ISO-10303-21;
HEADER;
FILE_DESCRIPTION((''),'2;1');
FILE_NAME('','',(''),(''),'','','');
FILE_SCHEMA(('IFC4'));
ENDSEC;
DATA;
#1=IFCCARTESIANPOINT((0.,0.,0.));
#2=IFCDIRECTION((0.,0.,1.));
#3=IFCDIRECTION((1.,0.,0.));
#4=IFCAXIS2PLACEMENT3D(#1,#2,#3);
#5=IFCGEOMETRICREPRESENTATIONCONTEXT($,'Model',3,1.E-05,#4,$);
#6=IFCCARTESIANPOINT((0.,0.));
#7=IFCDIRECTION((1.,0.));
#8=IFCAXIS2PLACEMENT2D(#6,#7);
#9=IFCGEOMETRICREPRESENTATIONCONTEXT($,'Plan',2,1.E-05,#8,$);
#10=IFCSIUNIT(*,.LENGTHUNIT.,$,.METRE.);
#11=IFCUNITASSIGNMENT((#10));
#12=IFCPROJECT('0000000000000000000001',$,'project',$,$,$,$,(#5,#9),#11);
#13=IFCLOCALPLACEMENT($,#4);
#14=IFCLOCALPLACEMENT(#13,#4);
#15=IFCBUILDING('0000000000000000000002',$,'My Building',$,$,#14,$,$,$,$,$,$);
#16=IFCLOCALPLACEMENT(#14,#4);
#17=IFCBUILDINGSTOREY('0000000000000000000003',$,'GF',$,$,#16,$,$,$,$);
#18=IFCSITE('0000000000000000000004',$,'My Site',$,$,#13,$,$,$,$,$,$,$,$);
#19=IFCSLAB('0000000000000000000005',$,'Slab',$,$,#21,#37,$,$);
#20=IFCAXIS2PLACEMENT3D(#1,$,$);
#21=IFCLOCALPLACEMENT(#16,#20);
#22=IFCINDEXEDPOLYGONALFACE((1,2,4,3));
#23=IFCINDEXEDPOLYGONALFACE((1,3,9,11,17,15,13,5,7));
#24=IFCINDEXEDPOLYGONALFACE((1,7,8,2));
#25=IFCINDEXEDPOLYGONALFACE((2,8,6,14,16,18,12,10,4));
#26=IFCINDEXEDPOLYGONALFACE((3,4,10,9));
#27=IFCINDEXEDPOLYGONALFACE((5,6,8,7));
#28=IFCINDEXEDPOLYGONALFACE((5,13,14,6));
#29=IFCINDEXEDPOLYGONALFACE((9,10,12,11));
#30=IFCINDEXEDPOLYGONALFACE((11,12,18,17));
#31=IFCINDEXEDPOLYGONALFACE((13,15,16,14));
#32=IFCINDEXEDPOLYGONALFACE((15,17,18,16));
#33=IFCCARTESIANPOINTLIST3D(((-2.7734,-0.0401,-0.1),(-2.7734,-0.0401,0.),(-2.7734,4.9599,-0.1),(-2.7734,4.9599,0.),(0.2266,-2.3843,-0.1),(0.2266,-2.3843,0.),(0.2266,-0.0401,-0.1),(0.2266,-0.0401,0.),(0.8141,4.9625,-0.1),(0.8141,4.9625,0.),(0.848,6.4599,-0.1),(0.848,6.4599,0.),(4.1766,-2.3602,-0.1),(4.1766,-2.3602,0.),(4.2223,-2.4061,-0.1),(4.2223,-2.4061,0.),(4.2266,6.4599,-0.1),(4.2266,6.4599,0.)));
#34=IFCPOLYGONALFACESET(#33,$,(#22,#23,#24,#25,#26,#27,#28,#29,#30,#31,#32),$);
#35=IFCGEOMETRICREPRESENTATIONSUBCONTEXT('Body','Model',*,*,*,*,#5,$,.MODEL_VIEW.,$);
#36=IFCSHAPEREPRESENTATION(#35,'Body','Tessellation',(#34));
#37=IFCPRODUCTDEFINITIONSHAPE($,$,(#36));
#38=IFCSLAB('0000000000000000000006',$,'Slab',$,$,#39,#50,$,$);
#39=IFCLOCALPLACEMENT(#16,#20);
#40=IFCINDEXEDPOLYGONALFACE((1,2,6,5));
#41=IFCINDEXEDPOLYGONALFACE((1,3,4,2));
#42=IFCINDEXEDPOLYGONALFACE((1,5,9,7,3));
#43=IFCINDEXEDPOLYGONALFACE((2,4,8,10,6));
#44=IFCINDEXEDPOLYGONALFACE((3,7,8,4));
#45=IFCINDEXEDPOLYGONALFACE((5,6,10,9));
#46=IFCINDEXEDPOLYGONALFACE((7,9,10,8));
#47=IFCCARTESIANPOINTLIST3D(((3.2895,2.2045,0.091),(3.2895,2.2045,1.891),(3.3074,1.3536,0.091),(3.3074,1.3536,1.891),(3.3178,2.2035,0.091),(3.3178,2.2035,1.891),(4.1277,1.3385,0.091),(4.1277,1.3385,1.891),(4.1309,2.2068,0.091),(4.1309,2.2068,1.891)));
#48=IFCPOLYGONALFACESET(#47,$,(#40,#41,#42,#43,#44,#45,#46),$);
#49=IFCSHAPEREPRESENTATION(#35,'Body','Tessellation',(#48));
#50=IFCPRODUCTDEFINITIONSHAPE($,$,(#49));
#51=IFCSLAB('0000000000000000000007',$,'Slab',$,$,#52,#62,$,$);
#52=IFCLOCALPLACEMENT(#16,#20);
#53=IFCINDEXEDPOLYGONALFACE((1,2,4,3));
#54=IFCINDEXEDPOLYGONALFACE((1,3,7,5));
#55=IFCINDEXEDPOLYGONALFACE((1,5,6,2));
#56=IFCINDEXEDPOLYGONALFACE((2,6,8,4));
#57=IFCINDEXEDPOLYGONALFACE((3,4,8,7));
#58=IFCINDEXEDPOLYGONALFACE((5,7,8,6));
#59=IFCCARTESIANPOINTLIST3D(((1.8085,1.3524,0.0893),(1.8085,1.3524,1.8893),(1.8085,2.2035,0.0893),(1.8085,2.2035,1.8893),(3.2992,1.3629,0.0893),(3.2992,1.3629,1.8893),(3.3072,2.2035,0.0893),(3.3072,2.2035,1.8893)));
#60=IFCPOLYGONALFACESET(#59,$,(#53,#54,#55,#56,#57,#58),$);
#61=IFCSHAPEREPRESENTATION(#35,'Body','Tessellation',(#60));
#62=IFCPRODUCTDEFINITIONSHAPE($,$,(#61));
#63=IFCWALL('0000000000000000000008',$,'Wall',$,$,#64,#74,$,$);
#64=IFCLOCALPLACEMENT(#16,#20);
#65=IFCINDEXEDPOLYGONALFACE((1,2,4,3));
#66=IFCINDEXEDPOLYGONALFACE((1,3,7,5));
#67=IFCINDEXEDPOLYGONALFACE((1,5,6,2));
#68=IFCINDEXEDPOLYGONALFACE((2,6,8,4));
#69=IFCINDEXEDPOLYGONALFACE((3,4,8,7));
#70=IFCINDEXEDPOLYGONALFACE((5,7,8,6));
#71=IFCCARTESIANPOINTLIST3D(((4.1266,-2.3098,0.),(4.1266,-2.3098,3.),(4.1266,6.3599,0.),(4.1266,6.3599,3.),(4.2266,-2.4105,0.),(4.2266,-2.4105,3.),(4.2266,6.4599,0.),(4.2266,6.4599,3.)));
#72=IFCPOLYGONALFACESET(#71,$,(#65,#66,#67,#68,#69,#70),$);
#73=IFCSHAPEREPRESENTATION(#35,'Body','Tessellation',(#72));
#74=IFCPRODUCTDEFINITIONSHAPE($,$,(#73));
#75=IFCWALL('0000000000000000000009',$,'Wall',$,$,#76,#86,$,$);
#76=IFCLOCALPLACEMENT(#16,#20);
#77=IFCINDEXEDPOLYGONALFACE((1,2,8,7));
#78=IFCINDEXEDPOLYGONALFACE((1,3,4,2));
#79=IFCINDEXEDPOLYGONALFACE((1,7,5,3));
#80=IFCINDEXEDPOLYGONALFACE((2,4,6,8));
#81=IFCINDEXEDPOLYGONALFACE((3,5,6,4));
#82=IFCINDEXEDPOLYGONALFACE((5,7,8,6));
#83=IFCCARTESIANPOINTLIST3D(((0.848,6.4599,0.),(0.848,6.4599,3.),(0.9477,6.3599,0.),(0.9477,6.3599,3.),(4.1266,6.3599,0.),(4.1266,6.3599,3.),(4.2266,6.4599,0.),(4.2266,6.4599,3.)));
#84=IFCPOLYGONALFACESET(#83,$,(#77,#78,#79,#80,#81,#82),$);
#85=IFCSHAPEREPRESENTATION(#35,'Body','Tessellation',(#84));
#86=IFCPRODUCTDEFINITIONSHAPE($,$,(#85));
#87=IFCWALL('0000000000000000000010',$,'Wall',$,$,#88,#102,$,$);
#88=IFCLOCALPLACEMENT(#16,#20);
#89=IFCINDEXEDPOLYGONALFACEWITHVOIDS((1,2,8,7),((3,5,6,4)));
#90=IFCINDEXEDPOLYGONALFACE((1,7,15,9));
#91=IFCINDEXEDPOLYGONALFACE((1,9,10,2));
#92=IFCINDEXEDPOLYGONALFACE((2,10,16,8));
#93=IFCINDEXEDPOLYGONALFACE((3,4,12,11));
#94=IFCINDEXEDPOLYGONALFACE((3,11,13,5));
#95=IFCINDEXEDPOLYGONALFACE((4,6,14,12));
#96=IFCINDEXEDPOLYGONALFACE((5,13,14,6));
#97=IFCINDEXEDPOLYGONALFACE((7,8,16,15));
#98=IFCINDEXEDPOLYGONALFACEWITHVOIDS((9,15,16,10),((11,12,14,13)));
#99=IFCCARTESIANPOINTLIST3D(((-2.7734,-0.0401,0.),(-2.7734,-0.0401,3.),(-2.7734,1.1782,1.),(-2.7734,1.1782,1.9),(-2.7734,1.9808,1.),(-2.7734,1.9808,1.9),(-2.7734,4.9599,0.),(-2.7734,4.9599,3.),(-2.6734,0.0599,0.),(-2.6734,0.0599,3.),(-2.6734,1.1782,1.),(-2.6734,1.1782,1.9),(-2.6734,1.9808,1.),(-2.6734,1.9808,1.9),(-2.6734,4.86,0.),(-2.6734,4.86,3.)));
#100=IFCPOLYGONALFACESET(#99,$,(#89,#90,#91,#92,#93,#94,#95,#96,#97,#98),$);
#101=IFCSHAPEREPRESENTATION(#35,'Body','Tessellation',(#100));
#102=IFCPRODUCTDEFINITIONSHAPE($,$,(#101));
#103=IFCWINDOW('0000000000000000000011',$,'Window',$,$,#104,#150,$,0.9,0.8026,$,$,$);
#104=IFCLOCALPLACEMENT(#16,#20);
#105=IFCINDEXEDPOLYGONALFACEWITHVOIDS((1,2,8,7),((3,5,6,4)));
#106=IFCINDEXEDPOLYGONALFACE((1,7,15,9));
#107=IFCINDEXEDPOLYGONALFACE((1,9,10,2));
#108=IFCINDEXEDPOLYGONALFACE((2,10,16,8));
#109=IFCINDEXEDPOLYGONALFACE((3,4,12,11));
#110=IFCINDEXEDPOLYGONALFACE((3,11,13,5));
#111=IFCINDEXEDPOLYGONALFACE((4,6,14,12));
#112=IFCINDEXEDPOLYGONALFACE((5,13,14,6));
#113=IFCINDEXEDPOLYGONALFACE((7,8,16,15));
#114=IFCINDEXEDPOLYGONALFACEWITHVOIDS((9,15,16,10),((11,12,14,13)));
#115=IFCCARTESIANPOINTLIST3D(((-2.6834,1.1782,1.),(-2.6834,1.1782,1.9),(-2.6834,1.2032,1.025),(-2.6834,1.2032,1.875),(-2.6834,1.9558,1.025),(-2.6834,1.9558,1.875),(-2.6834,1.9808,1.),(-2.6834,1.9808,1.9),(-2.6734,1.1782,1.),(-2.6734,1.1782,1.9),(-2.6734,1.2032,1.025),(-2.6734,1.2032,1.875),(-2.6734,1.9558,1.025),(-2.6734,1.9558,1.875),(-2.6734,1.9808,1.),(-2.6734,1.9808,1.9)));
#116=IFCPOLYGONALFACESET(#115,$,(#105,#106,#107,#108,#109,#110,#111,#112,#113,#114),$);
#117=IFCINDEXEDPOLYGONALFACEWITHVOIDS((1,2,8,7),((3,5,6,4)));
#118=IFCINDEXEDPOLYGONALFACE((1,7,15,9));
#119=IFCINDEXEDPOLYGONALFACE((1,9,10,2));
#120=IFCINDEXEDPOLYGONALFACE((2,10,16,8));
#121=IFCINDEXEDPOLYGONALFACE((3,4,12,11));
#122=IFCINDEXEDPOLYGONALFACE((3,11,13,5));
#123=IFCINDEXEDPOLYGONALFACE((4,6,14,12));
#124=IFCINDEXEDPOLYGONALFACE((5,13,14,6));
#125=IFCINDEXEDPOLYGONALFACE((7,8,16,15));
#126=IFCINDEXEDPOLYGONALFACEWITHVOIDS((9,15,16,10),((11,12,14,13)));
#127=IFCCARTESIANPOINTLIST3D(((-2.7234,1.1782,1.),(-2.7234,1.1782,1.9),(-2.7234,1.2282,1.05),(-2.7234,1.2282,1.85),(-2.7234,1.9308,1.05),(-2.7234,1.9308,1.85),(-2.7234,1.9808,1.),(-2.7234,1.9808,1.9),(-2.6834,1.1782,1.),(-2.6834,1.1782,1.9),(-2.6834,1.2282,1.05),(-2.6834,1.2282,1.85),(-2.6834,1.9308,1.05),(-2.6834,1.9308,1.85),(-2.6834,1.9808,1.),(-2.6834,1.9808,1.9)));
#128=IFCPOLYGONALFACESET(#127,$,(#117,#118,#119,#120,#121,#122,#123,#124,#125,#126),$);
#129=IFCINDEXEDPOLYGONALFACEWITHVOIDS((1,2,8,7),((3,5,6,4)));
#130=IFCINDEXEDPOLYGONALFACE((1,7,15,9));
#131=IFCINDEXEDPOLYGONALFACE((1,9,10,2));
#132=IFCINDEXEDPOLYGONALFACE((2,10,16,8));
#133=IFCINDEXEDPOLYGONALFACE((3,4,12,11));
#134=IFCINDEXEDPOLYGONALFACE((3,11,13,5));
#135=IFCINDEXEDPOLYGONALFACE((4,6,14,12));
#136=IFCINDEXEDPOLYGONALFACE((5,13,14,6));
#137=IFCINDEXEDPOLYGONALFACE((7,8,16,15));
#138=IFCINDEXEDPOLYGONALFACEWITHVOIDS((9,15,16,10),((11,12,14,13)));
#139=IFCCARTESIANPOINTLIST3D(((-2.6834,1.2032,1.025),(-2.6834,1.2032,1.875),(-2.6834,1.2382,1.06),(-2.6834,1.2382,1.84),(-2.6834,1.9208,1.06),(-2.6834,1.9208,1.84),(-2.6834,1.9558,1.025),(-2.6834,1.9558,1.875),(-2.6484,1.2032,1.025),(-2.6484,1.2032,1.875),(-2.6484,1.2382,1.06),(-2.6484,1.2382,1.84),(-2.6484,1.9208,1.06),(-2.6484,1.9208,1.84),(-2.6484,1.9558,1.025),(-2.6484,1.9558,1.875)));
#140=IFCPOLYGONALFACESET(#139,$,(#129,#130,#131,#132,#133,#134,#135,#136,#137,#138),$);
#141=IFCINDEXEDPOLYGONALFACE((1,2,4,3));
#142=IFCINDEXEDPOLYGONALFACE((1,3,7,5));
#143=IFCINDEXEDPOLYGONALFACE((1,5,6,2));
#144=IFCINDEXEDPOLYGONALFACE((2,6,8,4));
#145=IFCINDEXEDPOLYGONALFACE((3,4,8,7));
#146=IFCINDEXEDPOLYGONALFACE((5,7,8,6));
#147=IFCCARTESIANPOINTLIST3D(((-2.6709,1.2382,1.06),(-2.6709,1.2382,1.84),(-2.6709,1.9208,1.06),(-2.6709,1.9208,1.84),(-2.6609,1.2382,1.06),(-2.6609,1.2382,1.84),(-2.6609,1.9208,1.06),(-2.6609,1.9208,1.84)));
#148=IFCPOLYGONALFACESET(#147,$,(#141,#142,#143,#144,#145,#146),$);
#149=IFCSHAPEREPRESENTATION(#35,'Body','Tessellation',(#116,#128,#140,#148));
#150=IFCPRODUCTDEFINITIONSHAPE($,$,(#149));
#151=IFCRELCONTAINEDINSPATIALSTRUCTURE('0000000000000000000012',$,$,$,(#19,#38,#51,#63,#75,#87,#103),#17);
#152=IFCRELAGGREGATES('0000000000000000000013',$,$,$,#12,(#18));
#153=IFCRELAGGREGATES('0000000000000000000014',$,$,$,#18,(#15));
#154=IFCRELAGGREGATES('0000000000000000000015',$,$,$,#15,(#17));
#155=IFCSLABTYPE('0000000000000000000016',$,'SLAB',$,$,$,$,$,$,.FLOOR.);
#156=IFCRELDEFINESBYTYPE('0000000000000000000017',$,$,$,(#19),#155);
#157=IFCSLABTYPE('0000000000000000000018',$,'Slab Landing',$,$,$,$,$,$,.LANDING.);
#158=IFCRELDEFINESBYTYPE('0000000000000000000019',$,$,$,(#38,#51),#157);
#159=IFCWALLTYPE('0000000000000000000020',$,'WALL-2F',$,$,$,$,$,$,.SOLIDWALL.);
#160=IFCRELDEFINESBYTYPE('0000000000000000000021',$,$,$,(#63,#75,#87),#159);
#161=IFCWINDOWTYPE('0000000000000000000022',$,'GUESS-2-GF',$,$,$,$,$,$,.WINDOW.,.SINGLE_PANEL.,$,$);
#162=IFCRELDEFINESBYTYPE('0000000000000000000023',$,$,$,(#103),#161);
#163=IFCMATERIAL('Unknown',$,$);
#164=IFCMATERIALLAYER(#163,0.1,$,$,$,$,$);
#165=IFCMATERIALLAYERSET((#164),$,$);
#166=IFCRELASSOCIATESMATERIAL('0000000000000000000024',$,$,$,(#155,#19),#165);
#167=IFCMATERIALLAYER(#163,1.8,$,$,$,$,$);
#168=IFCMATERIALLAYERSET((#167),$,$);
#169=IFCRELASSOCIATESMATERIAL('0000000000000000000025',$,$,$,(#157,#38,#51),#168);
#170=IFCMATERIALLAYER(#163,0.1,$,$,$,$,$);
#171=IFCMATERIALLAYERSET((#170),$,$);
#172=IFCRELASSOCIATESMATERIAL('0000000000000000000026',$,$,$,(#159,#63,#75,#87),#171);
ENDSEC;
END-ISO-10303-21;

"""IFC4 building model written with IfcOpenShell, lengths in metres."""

from ifc_helpers import new_model, entity, si_unit, frame, origin_with_axes, origin_2d_with_axis, place, context, subcontext, project, spatial, line, indexed_curve, outline, extrude, shape, source, transform, mapped, material, layer, layer_set, layer_usage, type_object, type_shapes, element, fill, save


model = new_model("IFC4")

# Units and contexts
model_context = context("Model", 3, precision=1e-05, world=origin_with_axes())
plan_context = context("Plan", 2, precision=1e-05, world=origin_2d_with_axis())
body_context_1 = subcontext(model_context, "Body", "Model", "MODEL_VIEW")
body_context_2 = subcontext(plan_context, "Body", "Plan", "PLAN_VIEW")
ifc_project = project(units=[si_unit("LENGTHUNIT", "METRE")], contexts=[model_context, plan_context])

# Site, building, storey
site_placement = place(None, origin_with_axes())
site = spatial("IfcSite", under=ifc_project, at=site_placement, Name="My Site")
building_placement = place(site_placement, origin_with_axes())
building = spatial("IfcBuilding", under=site, at=building_placement, Name="My Building")
storey_placement = place(building_placement, origin_with_axes())
storey = spatial("IfcBuildingStorey", under=building, at=storey_placement, Name="GF")

# Slabs
ifc_material_1 = material(Name="Unknown")
ifc_layer_1 = layer(ifc_material_1, 0.1)
ifc_layer_set_1 = layer_set([ifc_layer_1])
ifc_layer_usage_1 = layer_usage(ifc_layer_set_1, "AXIS3", "POSITIVE", -0.1)
slab_type_1 = type_object("IfcSlabType", Name="SLAB", PredefinedType="FLOOR", material=ifc_layer_set_1)
slab_1_placement = place(storey_placement, frame((4.2223, -2.4061, 0.0), z_axis=(0.0, 0.0, 1.0), x_axis=(1.0, 0.0, 0.0)))
element("IfcSlab", 1, at=slab_1_placement, inside=storey, type_object=slab_type_1, material=ifc_layer_usage_1, Name="Slab", context=body_context_1, shape_type="SweptSolid", body=[
    extrude(outline(indexed_curve([(0.0, 0.0), (0.0043, 8.866), (-3.3742, 8.866), (-3.4082, 7.3687), (-6.9957, 7.366), (-6.9957, 2.366), (-3.9957, 2.366), (-3.9957, 0.0219), (-0.0457, 0.046), (0.0, 0.0)])), frame((0.0, 0.0, -0.1), z_axis=(0.0, 0.0, 1.0), x_axis=(1.0, 0.0, 0.0)), (0.0, 0.0, 1.0), 0.1),
])
ifc_layer_2 = layer(ifc_material_1, 1.8)
ifc_layer_set_2 = layer_set([ifc_layer_2])
slab_type_2 = type_object("IfcSlabType", Name="Slab Landing", PredefinedType="LANDING", material=ifc_layer_set_2)
ifc_layer_usage_2 = layer_usage(ifc_layer_set_2, "AXIS3", "POSITIVE", -1.8)
slab_2_placement = place(storey_placement, frame((3.3178, 2.2035, 1.891), z_axis=(0.0, 0.0, 1.0), x_axis=(1.0, 0.0, 0.0)))
element("IfcSlab", 2, at=slab_2_placement, inside=storey, type_object=slab_type_2, material=ifc_layer_usage_2, Name="Slab", context=body_context_1, shape_type="SweptSolid", body=[
    extrude(outline(indexed_curve([(0.0, 0.0), (0.8131, 0.0032), (0.8098, -0.865), (-0.0104, -0.8499), (-0.0284, 0.001), (0.0, 0.0)])), frame((0.0, 0.0, -1.8), z_axis=(0.0, 0.0, 1.0), x_axis=(1.0, 0.0, 0.0)), (0.0, 0.0, 1.0), 1.8),
])
ifc_layer_usage_3 = layer_usage(ifc_layer_set_2, "AXIS3", "POSITIVE", -1.8)
slab_3_placement = place(storey_placement, frame((1.8085, 2.2035, 1.8893), z_axis=(0.0, 0.0, 1.0), x_axis=(1.0, 0.0, 0.0)))
element("IfcSlab", 3, at=slab_3_placement, inside=storey, type_object=slab_type_2, material=ifc_layer_usage_3, Name="Slab", context=body_context_1, shape_type="SweptSolid", body=[
    extrude(outline(indexed_curve([(0.0, 0.0), (0.0, -0.8511), (1.4906, -0.8406), (1.4986, 0.0), (0.0, 0.0)])), frame((0.0, 0.0, -1.8), z_axis=(0.0, 0.0, 1.0), x_axis=(1.0, 0.0, 0.0)), (0.0, 0.0, 1.0), 1.8),
])

# Walls
ifc_layer_3 = layer(ifc_material_1, 0.1)
ifc_layer_set_3 = layer_set([ifc_layer_3])
ifc_layer_usage_4 = layer_usage(ifc_layer_set_3, "AXIS2", "POSITIVE", 0.0)
wall_type_1 = type_object("IfcWallType", Name="WALL-2F", PredefinedType="SOLIDWALL", material=ifc_layer_set_3)
wall_1_placement = place(storey_placement, frame((4.2266, -2.4105, 0.0), z_axis=(0.0, 0.0, 1.0), x_axis=(0.0, 1.0, 0.0)))
element("IfcWall", 4, at=wall_1_placement, inside=storey, type_object=wall_type_1, material=ifc_layer_usage_4, Name="Wall", context=body_context_1, shape_type="SweptSolid", body=[
    extrude(outline(indexed_curve([(0.0, 0.0), (0.1007, 0.1), (8.7704, 0.1), (8.8704, 0.0)], segments=[line(1, 2, 3, 4, 1)])), origin_with_axes(), (0.0, 0.0, 1.0), 3.0),
])
ifc_layer_usage_5 = layer_usage(ifc_layer_set_3, "AXIS2", "POSITIVE", 0.0)
wall_2_placement = place(storey_placement, frame((4.2266, 6.4599, 0.0), z_axis=(0.0, 0.0, 1.0), x_axis=(-1.0, 0.0, 0.0)))
element("IfcWall", 5, at=wall_2_placement, inside=storey, type_object=wall_type_1, material=ifc_layer_usage_5, Name="Wall", context=body_context_1, shape_type="SweptSolid", body=[
    extrude(outline(indexed_curve([(0.0, 0.0), (0.1, 0.1), (3.2789, 0.1), (3.3786, 0.0)], segments=[line(1, 2, 3, 4, 1)])), origin_with_axes(), (0.0, 0.0, 1.0), 3.0),
])

# Wall, opening, window
ifc_layer_usage_6 = layer_usage(ifc_layer_set_3, "AXIS2", "POSITIVE", 0.0)
wall_3_placement = place(storey_placement, frame((-2.7734, 4.8599, 0.0), z_axis=(0.0, 0.0, 1.0), x_axis=(0.0, -1.0, 0.0)))
wall_3 = element("IfcWall", 6, at=wall_3_placement, inside=storey, type_object=wall_type_1, material=ifc_layer_usage_6, Name="Wall", context=body_context_1, shape_type="SweptSolid", body=[
    extrude(outline(indexed_curve([(-0.1, 0.0), (-0.0001, 0.1), (4.8, 0.1), (4.9, 0.0)], segments=[line(1, 2, 3, 4, 1)])), origin_with_axes(), (0.0, 0.0, 1.0), 3.0),
])
shared_shape_1 = source(origin_with_axes(), body_context_1, "Body", "SweptSolid", [
    extrude(outline(indexed_curve([(0.0, 0.0), (0.8026, 0.0), (0.8026, 0.9), (0.0, 0.9)], segments=[line(1, 2, 3, 4, 1)])), frame((0.0, -0.6, 0.0), z_axis=(0.0, -1.0, 0.0), x_axis=(1.0, 0.0, 0.0)), (0.0, 0.0, -1.0), 1.2),
])
opening_1_placement = place(wall_3_placement, frame((2.8791, 0.0, 1.0), z_axis=(0.0, 0.0, 1.0), x_axis=(1.0, 0.0, 0.0)))
opening_1 = element("IfcOpeningElement", 7, at=opening_1_placement, cuts=wall_3, PredefinedType="OPENING", context=body_context_1, shape_type="MappedRepresentation", body=[
    mapped(shared_shape_1, transform((0.0, 0.0, 0.0), x_axis=(1.0, 0.0, 0.0), y_axis=(0.0, 1.0, 0.0), z_axis=(0.0, 0.0, 1.0), scale=1.0)),
])
window_type_1 = type_object("IfcWindowType", Name="GUESS-2-GF", PartitioningType="SINGLE_PANEL", PredefinedType="WINDOW")
shared_shape_2 = source(origin_with_axes(), body_context_1, "Body", "SweptSolid", [
    extrude(outline(indexed_curve([(0.0, 0.0), (0.8026, 0.0), (0.8026, 0.9), (0.0, 0.9)], segments=[line(1, 2, 3, 4, 1)]), holes=[indexed_curve([(0.025, 0.025), (0.7776, 0.025), (0.7776, 0.875), (0.025, 0.875)], segments=[line(1, 2, 3, 4, 1)])]), frame((0.0, 0.09, 0.0), z_axis=(0.0, -1.0, 0.0), x_axis=(1.0, 0.0, 0.0)), (0.0, 0.0, -1.0), 0.01),
    extrude(outline(indexed_curve([(0.0, 0.0), (0.8026, 0.0), (0.8026, 0.9), (0.0, 0.9)], segments=[line(1, 2, 3, 4, 1)]), holes=[indexed_curve([(0.05, 0.05), (0.7526, 0.05), (0.7526, 0.85), (0.05, 0.85)], segments=[line(1, 2, 3, 4, 1)])]), frame((0.0, 0.05, 0.0), z_axis=(0.0, -1.0, 0.0), x_axis=(1.0, 0.0, 0.0)), (0.0, 0.0, -1.0), 0.04),
    extrude(outline(indexed_curve([(0.0, 0.0), (0.7526, 0.0), (0.7526, 0.85), (0.0, 0.85)], segments=[line(1, 2, 3, 4, 1)]), holes=[indexed_curve([(0.035, 0.035), (0.7176, 0.035), (0.7176, 0.815), (0.035, 0.815)], segments=[line(1, 2, 3, 4, 1)])]), frame((0.025, 0.09, 0.025), z_axis=(0.0, -1.0, 0.0), x_axis=(1.0, 0.0, 0.0)), (0.0, 0.0, -1.0), 0.035),
    extrude(outline(indexed_curve([(0.035, 0.035), (0.7176, 0.035), (0.7176, 0.815), (0.035, 0.815)], segments=[line(1, 2, 3, 4, 1)])), frame((0.025, 0.1025, 0.025), z_axis=(0.0, -1.0, 0.0), x_axis=(1.0, 0.0, 0.0)), (0.0, 0.0, -1.0), 0.01),
])
shared_shape_3 = source(origin_with_axes(), body_context_2, "Body", "Curve2D", [
    entity("IfcIndexedPolyCurve", entity("IfcCartesianPointList2D", [[0.05, 0.05], [0.7526, 0.05]])),
    entity("IfcIndexedPolyCurve", entity("IfcCartesianPointList2D", [[0.0, 0.1], [0.025, 0.1], [0.025, 0.09], [0.05, 0.09], [0.05, 0.05], [0.0, 0.05]]), [entity("IfcLineIndex", [1, 2, 3, 4, 5, 6, 1])]),
    entity("IfcIndexedPolyCurve", entity("IfcCartesianPointList2D", [[0.8026, 0.1], [0.7776, 0.1], [0.7776, 0.09], [0.7526, 0.09], [0.7526, 0.05], [0.8026, 0.05]]), [entity("IfcLineIndex", [1, 2, 3, 4, 5, 6, 1])]),
    entity("IfcIndexedPolyCurve", entity("IfcCartesianPointList2D", [[0.025, 0.09], [0.06, 0.09], [0.06, 0.125], [0.025, 0.125]]), [entity("IfcLineIndex", [1, 2, 3, 4, 1])]),
    entity("IfcIndexedPolyCurve", entity("IfcCartesianPointList2D", [[0.7776, 0.09], [0.7426, 0.09], [0.7426, 0.125], [0.7776, 0.125]]), [entity("IfcLineIndex", [1, 2, 3, 4, 1])]),
    entity("IfcIndexedPolyCurve", entity("IfcCartesianPointList2D", [[0.06, 0.09], [0.7426, 0.09]])),
    entity("IfcIndexedPolyCurve", entity("IfcCartesianPointList2D", [[0.06, 0.125], [0.7426, 0.125]])),
    entity("IfcIndexedPolyCurve", entity("IfcCartesianPointList2D", [[0.06, 0.1075], [0.7426, 0.1075]])),
])
type_shapes(window_type_1, [shared_shape_2, shared_shape_3])
window_1_placement = place(opening_1_placement, frame((0.0, 0.0, 0.0), z_axis=(0.0, 0.0, 1.0), x_axis=(1.0, 0.0, 0.0)))
window_1 = element("IfcWindow", 8, at=window_1_placement, inside=storey, type_object=window_type_1, Name="Window", OverallHeight=0.9, OverallWidth=0.8026, shapes=[
    shape(body_context_1, "Body", "MappedRepresentation", [mapped(shared_shape_2, transform((0.0, 0.0, 0.0), x_axis=(1.0, 0.0, 0.0), y_axis=(0.0, 1.0, 0.0), z_axis=(0.0, 0.0, 1.0), scale=1.0))]),
    shape(body_context_2, "Body", "MappedRepresentation", [mapped(shared_shape_3, transform((0.0, 0.0, 0.0), x_axis=(1.0, 0.0, 0.0), y_axis=(0.0, 1.0, 0.0), z_axis=(0.0, 0.0, 1.0), scale=1.0))]),
])
fill(opening_1, window_1)

save(model, "model.ifc")
